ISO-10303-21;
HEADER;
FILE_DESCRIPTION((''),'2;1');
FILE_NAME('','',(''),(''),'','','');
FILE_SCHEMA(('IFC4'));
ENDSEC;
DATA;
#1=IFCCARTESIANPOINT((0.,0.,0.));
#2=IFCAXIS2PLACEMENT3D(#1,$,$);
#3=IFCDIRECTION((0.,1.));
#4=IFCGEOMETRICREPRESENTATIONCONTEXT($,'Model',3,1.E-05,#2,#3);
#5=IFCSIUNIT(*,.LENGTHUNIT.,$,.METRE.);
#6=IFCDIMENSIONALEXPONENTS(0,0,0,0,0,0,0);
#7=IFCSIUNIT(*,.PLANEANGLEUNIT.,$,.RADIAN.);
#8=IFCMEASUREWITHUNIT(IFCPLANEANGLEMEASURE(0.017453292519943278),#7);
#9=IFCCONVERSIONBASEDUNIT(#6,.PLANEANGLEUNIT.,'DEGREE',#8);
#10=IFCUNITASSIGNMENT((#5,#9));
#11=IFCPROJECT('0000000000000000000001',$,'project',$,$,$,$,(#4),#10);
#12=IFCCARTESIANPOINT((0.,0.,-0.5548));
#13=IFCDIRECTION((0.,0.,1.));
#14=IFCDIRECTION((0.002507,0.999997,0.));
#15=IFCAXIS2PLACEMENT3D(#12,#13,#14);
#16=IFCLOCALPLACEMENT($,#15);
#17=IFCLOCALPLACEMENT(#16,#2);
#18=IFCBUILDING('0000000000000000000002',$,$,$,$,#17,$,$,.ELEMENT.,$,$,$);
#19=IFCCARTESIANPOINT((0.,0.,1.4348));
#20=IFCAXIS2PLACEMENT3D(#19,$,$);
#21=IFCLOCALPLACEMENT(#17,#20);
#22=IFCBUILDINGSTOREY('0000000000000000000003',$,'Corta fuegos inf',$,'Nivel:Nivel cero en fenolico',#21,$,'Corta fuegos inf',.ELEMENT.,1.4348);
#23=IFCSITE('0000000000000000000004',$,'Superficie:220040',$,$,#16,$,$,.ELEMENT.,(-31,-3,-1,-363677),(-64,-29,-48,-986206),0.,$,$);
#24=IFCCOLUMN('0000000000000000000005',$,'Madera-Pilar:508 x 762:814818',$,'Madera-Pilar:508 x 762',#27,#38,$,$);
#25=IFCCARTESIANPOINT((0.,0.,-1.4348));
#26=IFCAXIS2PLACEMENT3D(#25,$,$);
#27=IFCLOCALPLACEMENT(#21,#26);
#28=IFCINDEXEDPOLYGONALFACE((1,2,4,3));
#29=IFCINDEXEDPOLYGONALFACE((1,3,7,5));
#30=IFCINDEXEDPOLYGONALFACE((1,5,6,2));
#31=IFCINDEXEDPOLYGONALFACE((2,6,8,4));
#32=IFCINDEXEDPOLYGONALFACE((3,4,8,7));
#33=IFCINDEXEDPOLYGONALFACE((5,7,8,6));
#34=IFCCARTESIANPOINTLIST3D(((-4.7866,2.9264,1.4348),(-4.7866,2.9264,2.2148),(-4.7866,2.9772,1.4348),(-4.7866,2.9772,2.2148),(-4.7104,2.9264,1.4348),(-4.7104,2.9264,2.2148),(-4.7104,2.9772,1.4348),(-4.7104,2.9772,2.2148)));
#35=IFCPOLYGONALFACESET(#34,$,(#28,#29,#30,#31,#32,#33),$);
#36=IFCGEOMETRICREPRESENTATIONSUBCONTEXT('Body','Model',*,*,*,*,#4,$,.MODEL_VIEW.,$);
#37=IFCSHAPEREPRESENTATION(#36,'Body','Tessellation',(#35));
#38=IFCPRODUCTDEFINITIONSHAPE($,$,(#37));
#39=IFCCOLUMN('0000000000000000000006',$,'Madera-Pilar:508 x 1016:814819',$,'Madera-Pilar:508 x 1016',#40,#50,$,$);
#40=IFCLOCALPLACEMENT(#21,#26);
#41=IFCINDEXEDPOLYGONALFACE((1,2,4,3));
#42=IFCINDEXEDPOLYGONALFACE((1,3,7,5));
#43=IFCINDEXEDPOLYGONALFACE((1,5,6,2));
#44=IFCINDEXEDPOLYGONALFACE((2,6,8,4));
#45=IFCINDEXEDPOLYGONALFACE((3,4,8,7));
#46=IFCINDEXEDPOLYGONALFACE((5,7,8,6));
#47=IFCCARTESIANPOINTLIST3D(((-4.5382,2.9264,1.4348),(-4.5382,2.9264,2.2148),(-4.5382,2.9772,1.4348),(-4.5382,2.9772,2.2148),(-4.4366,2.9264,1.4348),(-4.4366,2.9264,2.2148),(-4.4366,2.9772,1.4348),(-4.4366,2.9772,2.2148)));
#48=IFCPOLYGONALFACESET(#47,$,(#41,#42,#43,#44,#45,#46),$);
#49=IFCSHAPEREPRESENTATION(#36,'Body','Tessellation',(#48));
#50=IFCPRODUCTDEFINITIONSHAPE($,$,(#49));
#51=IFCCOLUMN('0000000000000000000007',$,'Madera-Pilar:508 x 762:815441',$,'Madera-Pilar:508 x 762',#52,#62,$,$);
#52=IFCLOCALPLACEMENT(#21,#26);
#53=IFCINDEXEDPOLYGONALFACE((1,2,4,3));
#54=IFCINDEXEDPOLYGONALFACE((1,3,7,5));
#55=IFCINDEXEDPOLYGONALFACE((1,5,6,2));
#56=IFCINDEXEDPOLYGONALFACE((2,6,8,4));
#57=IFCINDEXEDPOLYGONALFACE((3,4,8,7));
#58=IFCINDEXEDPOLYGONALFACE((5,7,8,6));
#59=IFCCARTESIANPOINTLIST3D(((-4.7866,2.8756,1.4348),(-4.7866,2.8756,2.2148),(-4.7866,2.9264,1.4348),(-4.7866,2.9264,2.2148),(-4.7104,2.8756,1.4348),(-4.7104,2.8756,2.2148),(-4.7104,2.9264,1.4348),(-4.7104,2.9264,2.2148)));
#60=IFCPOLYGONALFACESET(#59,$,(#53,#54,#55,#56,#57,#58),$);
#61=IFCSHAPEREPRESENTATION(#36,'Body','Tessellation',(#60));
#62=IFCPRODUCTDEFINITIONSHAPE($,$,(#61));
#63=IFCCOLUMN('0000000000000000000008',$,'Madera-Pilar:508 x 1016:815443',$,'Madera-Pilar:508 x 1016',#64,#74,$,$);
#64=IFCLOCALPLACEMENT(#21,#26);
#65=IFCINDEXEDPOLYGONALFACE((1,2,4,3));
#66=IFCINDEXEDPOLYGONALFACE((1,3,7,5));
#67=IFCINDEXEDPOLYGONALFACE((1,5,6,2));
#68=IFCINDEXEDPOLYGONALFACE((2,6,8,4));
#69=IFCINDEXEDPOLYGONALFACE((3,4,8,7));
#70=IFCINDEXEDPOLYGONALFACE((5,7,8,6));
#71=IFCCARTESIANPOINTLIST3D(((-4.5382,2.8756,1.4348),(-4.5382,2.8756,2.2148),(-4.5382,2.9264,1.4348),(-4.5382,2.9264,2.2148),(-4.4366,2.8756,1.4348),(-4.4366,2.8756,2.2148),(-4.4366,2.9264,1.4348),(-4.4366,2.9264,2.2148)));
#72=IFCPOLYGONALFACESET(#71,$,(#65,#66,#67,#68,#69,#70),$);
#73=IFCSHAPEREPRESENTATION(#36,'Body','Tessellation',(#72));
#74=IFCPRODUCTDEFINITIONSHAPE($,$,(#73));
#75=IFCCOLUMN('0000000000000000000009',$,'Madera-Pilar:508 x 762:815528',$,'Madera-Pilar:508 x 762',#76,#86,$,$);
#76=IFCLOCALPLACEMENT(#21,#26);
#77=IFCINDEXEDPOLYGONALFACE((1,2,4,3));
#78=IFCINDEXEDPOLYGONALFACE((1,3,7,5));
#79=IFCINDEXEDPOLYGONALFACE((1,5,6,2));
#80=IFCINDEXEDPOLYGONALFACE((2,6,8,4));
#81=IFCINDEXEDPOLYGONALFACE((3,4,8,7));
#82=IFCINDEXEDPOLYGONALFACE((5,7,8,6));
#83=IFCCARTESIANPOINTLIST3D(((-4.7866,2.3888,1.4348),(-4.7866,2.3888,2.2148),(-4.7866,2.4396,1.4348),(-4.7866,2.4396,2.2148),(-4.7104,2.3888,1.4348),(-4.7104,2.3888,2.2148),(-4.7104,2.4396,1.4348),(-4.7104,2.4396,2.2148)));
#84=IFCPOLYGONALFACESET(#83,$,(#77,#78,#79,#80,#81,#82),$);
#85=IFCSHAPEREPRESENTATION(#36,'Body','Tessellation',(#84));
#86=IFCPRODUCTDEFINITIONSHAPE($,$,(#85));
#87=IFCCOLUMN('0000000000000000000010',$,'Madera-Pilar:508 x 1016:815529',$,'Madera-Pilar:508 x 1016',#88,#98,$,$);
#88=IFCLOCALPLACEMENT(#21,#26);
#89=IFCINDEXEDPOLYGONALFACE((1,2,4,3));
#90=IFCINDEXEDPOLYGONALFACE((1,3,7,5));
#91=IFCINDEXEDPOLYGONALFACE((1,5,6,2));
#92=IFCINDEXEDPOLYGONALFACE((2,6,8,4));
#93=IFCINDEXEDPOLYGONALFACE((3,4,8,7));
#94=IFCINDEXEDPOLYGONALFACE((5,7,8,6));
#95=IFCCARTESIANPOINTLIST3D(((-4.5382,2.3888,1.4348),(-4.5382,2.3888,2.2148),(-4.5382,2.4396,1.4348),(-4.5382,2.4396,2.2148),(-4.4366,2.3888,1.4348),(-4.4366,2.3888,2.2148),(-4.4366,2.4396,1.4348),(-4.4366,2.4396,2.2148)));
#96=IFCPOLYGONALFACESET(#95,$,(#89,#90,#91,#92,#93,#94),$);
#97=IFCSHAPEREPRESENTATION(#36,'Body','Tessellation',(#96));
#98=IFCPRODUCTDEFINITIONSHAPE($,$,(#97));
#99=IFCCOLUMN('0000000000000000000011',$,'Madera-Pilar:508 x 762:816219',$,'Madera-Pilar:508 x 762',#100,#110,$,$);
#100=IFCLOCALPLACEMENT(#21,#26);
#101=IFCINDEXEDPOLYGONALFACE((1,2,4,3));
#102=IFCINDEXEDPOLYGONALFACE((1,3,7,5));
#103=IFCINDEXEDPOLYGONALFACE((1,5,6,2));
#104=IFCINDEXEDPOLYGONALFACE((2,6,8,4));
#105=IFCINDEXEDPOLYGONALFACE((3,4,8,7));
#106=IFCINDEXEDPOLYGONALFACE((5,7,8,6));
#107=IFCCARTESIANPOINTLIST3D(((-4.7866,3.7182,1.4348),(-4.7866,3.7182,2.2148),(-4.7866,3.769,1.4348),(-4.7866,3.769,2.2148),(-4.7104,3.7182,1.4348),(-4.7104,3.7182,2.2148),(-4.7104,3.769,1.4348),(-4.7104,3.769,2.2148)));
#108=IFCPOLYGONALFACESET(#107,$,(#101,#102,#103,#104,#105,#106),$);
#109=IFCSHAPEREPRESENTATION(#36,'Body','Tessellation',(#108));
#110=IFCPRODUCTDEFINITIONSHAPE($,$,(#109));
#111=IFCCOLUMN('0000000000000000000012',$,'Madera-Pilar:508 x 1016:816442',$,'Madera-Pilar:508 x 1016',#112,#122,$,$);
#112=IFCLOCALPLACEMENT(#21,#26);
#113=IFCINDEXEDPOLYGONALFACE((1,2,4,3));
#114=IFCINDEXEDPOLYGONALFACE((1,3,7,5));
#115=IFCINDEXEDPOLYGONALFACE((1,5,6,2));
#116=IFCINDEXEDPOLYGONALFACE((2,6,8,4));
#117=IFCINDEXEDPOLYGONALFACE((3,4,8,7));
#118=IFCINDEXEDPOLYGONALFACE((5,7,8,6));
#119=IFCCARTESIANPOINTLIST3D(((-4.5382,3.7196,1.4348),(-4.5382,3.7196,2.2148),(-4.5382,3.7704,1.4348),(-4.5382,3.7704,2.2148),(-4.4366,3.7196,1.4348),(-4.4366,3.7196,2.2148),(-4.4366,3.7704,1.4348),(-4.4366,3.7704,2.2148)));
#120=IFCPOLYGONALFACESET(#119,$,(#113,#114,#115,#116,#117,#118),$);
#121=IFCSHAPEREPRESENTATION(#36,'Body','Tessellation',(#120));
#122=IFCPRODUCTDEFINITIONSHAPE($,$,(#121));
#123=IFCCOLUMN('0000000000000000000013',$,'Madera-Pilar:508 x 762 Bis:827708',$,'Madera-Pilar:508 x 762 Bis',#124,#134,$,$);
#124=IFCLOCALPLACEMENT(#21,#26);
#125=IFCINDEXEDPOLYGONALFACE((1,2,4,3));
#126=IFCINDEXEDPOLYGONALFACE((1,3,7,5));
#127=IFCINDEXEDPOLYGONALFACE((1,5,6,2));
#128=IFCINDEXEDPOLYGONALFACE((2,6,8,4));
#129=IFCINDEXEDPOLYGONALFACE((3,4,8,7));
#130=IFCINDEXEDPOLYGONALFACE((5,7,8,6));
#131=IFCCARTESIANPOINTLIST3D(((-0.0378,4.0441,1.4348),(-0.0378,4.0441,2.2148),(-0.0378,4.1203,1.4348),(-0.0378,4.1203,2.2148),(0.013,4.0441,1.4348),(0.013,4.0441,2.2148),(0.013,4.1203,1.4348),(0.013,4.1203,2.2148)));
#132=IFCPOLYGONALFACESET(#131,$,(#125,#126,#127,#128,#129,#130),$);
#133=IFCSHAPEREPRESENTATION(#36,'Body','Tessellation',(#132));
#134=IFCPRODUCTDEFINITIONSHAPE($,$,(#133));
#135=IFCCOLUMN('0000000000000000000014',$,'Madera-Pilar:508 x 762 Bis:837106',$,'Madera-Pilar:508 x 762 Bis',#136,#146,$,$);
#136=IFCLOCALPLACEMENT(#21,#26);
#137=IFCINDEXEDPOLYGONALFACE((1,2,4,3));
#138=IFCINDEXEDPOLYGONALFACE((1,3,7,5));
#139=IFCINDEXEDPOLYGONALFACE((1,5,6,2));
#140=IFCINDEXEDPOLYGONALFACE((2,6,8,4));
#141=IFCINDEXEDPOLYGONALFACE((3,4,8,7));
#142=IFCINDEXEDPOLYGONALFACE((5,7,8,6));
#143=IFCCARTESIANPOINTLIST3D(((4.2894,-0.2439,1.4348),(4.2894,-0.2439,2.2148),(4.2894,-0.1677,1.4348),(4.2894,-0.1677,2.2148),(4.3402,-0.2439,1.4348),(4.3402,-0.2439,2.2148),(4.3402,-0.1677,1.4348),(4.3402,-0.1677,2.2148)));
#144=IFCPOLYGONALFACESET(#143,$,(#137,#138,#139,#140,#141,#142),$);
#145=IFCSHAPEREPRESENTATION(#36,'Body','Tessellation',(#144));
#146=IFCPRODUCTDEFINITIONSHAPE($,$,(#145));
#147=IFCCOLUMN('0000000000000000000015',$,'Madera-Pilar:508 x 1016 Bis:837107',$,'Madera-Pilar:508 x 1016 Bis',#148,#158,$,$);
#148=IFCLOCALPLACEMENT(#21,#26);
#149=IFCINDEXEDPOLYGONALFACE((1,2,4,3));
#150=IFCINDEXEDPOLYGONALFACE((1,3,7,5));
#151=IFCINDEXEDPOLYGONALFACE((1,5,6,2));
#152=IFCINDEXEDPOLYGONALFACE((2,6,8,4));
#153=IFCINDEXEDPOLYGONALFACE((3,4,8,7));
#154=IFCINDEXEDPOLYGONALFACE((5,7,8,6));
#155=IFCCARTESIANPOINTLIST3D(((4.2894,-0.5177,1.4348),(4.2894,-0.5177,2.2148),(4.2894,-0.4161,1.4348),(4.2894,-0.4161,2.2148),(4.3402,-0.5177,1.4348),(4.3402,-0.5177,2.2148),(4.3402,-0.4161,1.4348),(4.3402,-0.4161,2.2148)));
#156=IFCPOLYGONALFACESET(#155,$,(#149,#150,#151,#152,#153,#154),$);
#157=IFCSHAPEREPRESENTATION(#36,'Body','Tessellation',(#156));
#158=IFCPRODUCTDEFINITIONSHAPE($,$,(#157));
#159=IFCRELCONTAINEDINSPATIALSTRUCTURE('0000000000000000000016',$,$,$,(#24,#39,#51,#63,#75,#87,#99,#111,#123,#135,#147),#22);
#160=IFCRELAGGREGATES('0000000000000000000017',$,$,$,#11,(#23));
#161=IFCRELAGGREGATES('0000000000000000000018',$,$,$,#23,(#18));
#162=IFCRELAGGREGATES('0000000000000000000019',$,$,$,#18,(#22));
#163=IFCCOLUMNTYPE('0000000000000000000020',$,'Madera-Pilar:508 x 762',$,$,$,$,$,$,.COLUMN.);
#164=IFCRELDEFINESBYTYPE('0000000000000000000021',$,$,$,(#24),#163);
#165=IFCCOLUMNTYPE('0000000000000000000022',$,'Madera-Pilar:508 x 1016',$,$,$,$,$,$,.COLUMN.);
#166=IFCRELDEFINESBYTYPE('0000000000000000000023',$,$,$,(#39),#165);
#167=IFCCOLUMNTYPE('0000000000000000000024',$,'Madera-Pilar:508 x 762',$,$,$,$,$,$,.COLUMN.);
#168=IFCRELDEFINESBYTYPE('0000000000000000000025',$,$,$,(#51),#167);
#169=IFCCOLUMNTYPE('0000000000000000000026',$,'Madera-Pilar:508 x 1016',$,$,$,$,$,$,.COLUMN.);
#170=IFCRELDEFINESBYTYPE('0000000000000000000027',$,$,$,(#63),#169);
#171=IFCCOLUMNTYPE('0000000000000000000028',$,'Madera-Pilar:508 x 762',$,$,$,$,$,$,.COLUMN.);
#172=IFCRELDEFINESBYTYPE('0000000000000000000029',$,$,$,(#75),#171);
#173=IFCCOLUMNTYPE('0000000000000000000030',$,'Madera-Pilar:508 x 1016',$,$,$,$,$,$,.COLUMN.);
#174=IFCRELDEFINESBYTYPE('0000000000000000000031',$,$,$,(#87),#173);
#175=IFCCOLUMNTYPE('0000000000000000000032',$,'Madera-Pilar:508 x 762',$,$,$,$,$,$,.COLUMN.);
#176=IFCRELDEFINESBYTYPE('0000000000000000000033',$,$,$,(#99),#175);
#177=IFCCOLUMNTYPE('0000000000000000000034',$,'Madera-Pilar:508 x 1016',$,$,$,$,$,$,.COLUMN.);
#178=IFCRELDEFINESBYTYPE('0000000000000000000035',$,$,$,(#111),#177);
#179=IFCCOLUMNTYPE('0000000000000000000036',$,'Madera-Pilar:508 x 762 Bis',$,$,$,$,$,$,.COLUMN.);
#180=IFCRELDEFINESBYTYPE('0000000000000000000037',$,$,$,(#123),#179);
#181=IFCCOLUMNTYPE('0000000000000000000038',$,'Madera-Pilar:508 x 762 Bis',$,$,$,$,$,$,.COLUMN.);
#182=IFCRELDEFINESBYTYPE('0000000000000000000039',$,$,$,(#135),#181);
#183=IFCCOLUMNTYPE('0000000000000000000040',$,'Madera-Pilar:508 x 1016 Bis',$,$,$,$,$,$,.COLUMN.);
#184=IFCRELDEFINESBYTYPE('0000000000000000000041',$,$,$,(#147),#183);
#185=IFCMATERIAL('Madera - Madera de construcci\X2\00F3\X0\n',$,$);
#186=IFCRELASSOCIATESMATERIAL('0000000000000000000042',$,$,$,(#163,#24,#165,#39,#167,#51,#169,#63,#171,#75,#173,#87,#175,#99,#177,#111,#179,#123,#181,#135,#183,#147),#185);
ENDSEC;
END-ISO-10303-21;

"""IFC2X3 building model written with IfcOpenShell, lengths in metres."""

from ifc_helpers import new_model, entity, si_unit, converted_unit, direction, frame, frame_2d, origin, origin_2d_with_axis, place, context, subcontext, project, spatial, rectangle, extrude, source, transform, mapped, material, type_object, type_shapes, element, save


model = new_model("IFC2X3")

# Units and contexts
model_context = context("Model", 3, precision=1e-05, world=origin(), true_north=direction((0.0, 1.0)))
body_context = subcontext(model_context, "Body", "Model", "MODEL_VIEW")
ifc_project = project(units=[si_unit("LENGTHUNIT", "METRE"), converted_unit("PLANEANGLEUNIT", "DEGREE", entity("IfcPlaneAngleMeasure", 0.017453292519943278), si_unit("PLANEANGLEUNIT", "RADIAN"), dimensions=[0, 0, 0, 0, 0, 0, 0])], contexts=[model_context])

# Site, building, storey
site_placement = place(None, frame((0.0, 0.0, -0.5548), z_axis=(0.0, 0.0, 1.0), x_axis=(0.002507, 0.999997, 0.0)))
site = spatial("IfcSite", under=ifc_project, at=site_placement, Name="Superficie:220040", CompositionType="ELEMENT", RefLatitude=(-31, -3, -1, -363677), RefLongitude=(-64, -29, -48, -986206), RefElevation=0.0)
building_placement = place(site_placement, origin())
building = spatial("IfcBuilding", under=site, at=building_placement, CompositionType="ELEMENT")
storey_placement = place(building_placement, frame((0.0, 0.0, 1.4348)))
storey = spatial("IfcBuildingStorey", under=building, at=storey_placement, Name="Corta fuegos inf", ObjectType="Nivel:Nivel cero en fenolico", LongName="Corta fuegos inf", CompositionType="ELEMENT", Elevation=1.4348)

# Columns
ifc_material = material(Name="Madera - Madera de construcción")
column_type_1 = type_object("IfcColumnType", Name="Madera-Pilar:508 x 762", PredefinedType="COLUMN", material=ifc_material)
shared_shape_1 = source(origin(), body_context, "Body", "SweptSolid", [
    extrude(rectangle(XDim=0.0762, YDim=0.0508, at=origin_2d_with_axis()), frame((-4.7485, 2.9518, 1.4348), z_axis=(0.0, 0.0, 1.0), x_axis=(-1.0, 0.0, 0.0)), (0.0, 0.0, 1.0), 0.78),
])
type_shapes(column_type_1, [shared_shape_1])
column_1_placement = place(storey_placement, frame((0.0, 0.0, -1.4348)))
element("IfcColumn", 1, at=column_1_placement, inside=storey, type_object=column_type_1, material=ifc_material, Name="Madera-Pilar:508 x 762:814818", ObjectType="Madera-Pilar:508 x 762", context=body_context, shape_type="MappedRepresentation", body=[
    mapped(shared_shape_1, transform((0.0, 0.0, 0.0), scale=1.0)),
])
column_type_2 = type_object("IfcColumnType", Name="Madera-Pilar:508 x 1016", PredefinedType="COLUMN", material=ifc_material)
shared_shape_2 = source(origin(), body_context, "Body", "SweptSolid", [
    extrude(rectangle(XDim=0.1016, YDim=0.0508, at=frame_2d((0.0, 0.0), x_axis=(1.0, 0.0))), frame((-4.4874, 2.9518, 1.4348), z_axis=(0.0, 0.0, 1.0), x_axis=(-1.0, 0.0, 0.0)), (0.0, 0.0, 1.0), 0.78),
])
type_shapes(column_type_2, [shared_shape_2])
column_2_placement = place(storey_placement, frame((0.0, 0.0, -1.4348)))
element("IfcColumn", 2, at=column_2_placement, inside=storey, type_object=column_type_2, material=ifc_material, Name="Madera-Pilar:508 x 1016:814819", ObjectType="Madera-Pilar:508 x 1016", context=body_context, shape_type="MappedRepresentation", body=[
    mapped(shared_shape_2, transform((0.0, 0.0, 0.0), scale=1.0)),
])
column_type_3 = type_object("IfcColumnType", Name="Madera-Pilar:508 x 762", PredefinedType="COLUMN", material=ifc_material)
shared_shape_3 = source(origin(), body_context, "Body", "SweptSolid", [
    extrude(rectangle(XDim=0.0762, YDim=0.0508, at=frame_2d((0.0, 0.0), x_axis=(1.0, 0.0))), frame((-4.7485, 2.901, 1.4348), z_axis=(0.0, 0.0, 1.0), x_axis=(-1.0, 0.0, 0.0)), (0.0, 0.0, 1.0), 0.78),
])
type_shapes(column_type_3, [shared_shape_3])
column_3_placement = place(storey_placement, frame((0.0, 0.0, -1.4348)))
element("IfcColumn", 3, at=column_3_placement, inside=storey, type_object=column_type_3, material=ifc_material, Name="Madera-Pilar:508 x 762:815441", ObjectType="Madera-Pilar:508 x 762", context=body_context, shape_type="MappedRepresentation", body=[
    mapped(shared_shape_3, transform((0.0, 0.0, 0.0), scale=1.0)),
])
column_type_4 = type_object("IfcColumnType", Name="Madera-Pilar:508 x 1016", PredefinedType="COLUMN", material=ifc_material)
shared_shape_4 = source(origin(), body_context, "Body", "SweptSolid", [
    extrude(rectangle(XDim=0.1016, YDim=0.0508, at=frame_2d((0.0, 0.0), x_axis=(1.0, 0.0))), frame((-4.4874, 2.901, 1.4348), z_axis=(0.0, 0.0, 1.0), x_axis=(-1.0, 0.0, 0.0)), (0.0, 0.0, 1.0), 0.78),
])
type_shapes(column_type_4, [shared_shape_4])
column_4_placement = place(storey_placement, frame((0.0, 0.0, -1.4348)))
element("IfcColumn", 4, at=column_4_placement, inside=storey, type_object=column_type_4, material=ifc_material, Name="Madera-Pilar:508 x 1016:815443", ObjectType="Madera-Pilar:508 x 1016", context=body_context, shape_type="MappedRepresentation", body=[
    mapped(shared_shape_4, transform((0.0, 0.0, 0.0), scale=1.0)),
])
column_type_5 = type_object("IfcColumnType", Name="Madera-Pilar:508 x 762", PredefinedType="COLUMN", material=ifc_material)
shared_shape_5 = source(origin(), body_context, "Body", "SweptSolid", [
    extrude(rectangle(XDim=0.0762, YDim=0.0508, at=frame_2d((0.0, 0.0), x_axis=(1.0, 0.0))), frame((-4.7485, 2.4142, 1.4348), z_axis=(0.0, 0.0, 1.0), x_axis=(-1.0, 0.0, 0.0)), (0.0, 0.0, 1.0), 0.78),
])
type_shapes(column_type_5, [shared_shape_5])
column_5_placement = place(storey_placement, frame((0.0, 0.0, -1.4348)))
element("IfcColumn", 5, at=column_5_placement, inside=storey, type_object=column_type_5, material=ifc_material, Name="Madera-Pilar:508 x 762:815528", ObjectType="Madera-Pilar:508 x 762", context=body_context, shape_type="MappedRepresentation", body=[
    mapped(shared_shape_5, transform((0.0, 0.0, 0.0), scale=1.0)),
])
column_type_6 = type_object("IfcColumnType", Name="Madera-Pilar:508 x 1016", PredefinedType="COLUMN", material=ifc_material)
shared_shape_6 = source(origin(), body_context, "Body", "SweptSolid", [
    extrude(rectangle(XDim=0.1016, YDim=0.0508, at=frame_2d((0.0, 0.0), x_axis=(1.0, 0.0))), frame((-4.4874, 2.4142, 1.4348), z_axis=(0.0, 0.0, 1.0), x_axis=(-1.0, 0.0, 0.0)), (0.0, 0.0, 1.0), 0.78),
])
type_shapes(column_type_6, [shared_shape_6])
column_6_placement = place(storey_placement, frame((0.0, 0.0, -1.4348)))
element("IfcColumn", 6, at=column_6_placement, inside=storey, type_object=column_type_6, material=ifc_material, Name="Madera-Pilar:508 x 1016:815529", ObjectType="Madera-Pilar:508 x 1016", context=body_context, shape_type="MappedRepresentation", body=[
    mapped(shared_shape_6, transform((0.0, 0.0, 0.0), scale=1.0)),
])
column_type_7 = type_object("IfcColumnType", Name="Madera-Pilar:508 x 762", PredefinedType="COLUMN", material=ifc_material)
shared_shape_7 = source(origin(), body_context, "Body", "SweptSolid", [
    extrude(rectangle(XDim=0.0762, YDim=0.0508, at=origin_2d_with_axis()), frame((-4.7485, 3.7436, 1.4348), z_axis=(0.0, 0.0, 1.0), x_axis=(-1.0, 0.0, 0.0)), (0.0, 0.0, 1.0), 0.78),
])
type_shapes(column_type_7, [shared_shape_7])
column_7_placement = place(storey_placement, frame((0.0, 0.0, -1.4348)))
element("IfcColumn", 7, at=column_7_placement, inside=storey, type_object=column_type_7, material=ifc_material, Name="Madera-Pilar:508 x 762:816219", ObjectType="Madera-Pilar:508 x 762", context=body_context, shape_type="MappedRepresentation", body=[
    mapped(shared_shape_7, transform((0.0, 0.0, 0.0), scale=1.0)),
])
column_type_8 = type_object("IfcColumnType", Name="Madera-Pilar:508 x 1016", PredefinedType="COLUMN", material=ifc_material)
shared_shape_8 = source(origin(), body_context, "Body", "SweptSolid", [
    extrude(rectangle(XDim=0.1016, YDim=0.0508, at=frame_2d((0.0, 0.0), x_axis=(1.0, 0.0))), frame((-4.4874, 3.745, 1.4348), z_axis=(0.0, 0.0, 1.0), x_axis=(-1.0, 0.0, 0.0)), (0.0, 0.0, 1.0), 0.78),
])
type_shapes(column_type_8, [shared_shape_8])
column_8_placement = place(storey_placement, frame((0.0, 0.0, -1.4348)))
element("IfcColumn", 8, at=column_8_placement, inside=storey, type_object=column_type_8, material=ifc_material, Name="Madera-Pilar:508 x 1016:816442", ObjectType="Madera-Pilar:508 x 1016", context=body_context, shape_type="MappedRepresentation", body=[
    mapped(shared_shape_8, transform((0.0, 0.0, 0.0), scale=1.0)),
])
column_type_9 = type_object("IfcColumnType", Name="Madera-Pilar:508 x 762 Bis", PredefinedType="COLUMN", material=ifc_material)
shared_shape_9 = source(origin(), body_context, "Body", "SweptSolid", [
    extrude(rectangle(XDim=0.0508, YDim=0.0762, at=frame_2d((0.0, 0.0), x_axis=(1.0, 0.0))), frame((-0.0124, 4.0822, 1.4348), z_axis=(0.0, 0.0, 1.0), x_axis=(-1.0, 0.0, 0.0)), (0.0, 0.0, 1.0), 0.78),
])
type_shapes(column_type_9, [shared_shape_9])
column_9_placement = place(storey_placement, frame((0.0, 0.0, -1.4348)))
element("IfcColumn", 9, at=column_9_placement, inside=storey, type_object=column_type_9, material=ifc_material, Name="Madera-Pilar:508 x 762 Bis:827708", ObjectType="Madera-Pilar:508 x 762 Bis", context=body_context, shape_type="MappedRepresentation", body=[
    mapped(shared_shape_9, transform((0.0, 0.0, 0.0), scale=1.0)),
])
column_type_10 = type_object("IfcColumnType", Name="Madera-Pilar:508 x 762 Bis", PredefinedType="COLUMN", material=ifc_material)
shared_shape_10 = source(origin(), body_context, "Body", "SweptSolid", [
    extrude(rectangle(XDim=0.0508, YDim=0.0762, at=frame_2d((0.0, 0.0), x_axis=(1.0, 0.0))), frame((4.3148, -0.2058, 1.4348), z_axis=(0.0, 0.0, 1.0), x_axis=(-1.0, 0.0, 0.0)), (0.0, 0.0, 1.0), 0.78),
])
type_shapes(column_type_10, [shared_shape_10])
column_10_placement = place(storey_placement, frame((0.0, 0.0, -1.4348)))
element("IfcColumn", 10, at=column_10_placement, inside=storey, type_object=column_type_10, material=ifc_material, Name="Madera-Pilar:508 x 762 Bis:837106", ObjectType="Madera-Pilar:508 x 762 Bis", context=body_context, shape_type="MappedRepresentation", body=[
    mapped(shared_shape_10, transform((0.0, 0.0, 0.0), scale=1.0)),
])
column_type_11 = type_object("IfcColumnType", Name="Madera-Pilar:508 x 1016 Bis", PredefinedType="COLUMN", material=ifc_material)
shared_shape_11 = source(origin(), body_context, "Body", "SweptSolid", [
    extrude(rectangle(XDim=0.0508, YDim=0.1016, at=frame_2d((0.0, 0.0), x_axis=(1.0, 0.0))), frame((4.3148, -0.4669, 1.4348)), (0.0, 0.0, 1.0), 0.78),
])
type_shapes(column_type_11, [shared_shape_11])
column_11_placement = place(storey_placement, frame((0.0, 0.0, -1.4348)))
element("IfcColumn", 11, at=column_11_placement, inside=storey, type_object=column_type_11, material=ifc_material, Name="Madera-Pilar:508 x 1016 Bis:837107", ObjectType="Madera-Pilar:508 x 1016 Bis", context=body_context, shape_type="MappedRepresentation", body=[
    mapped(shared_shape_11, transform((0.0, 0.0, 0.0), scale=1.0)),
])

save(model, "model.ifc")
